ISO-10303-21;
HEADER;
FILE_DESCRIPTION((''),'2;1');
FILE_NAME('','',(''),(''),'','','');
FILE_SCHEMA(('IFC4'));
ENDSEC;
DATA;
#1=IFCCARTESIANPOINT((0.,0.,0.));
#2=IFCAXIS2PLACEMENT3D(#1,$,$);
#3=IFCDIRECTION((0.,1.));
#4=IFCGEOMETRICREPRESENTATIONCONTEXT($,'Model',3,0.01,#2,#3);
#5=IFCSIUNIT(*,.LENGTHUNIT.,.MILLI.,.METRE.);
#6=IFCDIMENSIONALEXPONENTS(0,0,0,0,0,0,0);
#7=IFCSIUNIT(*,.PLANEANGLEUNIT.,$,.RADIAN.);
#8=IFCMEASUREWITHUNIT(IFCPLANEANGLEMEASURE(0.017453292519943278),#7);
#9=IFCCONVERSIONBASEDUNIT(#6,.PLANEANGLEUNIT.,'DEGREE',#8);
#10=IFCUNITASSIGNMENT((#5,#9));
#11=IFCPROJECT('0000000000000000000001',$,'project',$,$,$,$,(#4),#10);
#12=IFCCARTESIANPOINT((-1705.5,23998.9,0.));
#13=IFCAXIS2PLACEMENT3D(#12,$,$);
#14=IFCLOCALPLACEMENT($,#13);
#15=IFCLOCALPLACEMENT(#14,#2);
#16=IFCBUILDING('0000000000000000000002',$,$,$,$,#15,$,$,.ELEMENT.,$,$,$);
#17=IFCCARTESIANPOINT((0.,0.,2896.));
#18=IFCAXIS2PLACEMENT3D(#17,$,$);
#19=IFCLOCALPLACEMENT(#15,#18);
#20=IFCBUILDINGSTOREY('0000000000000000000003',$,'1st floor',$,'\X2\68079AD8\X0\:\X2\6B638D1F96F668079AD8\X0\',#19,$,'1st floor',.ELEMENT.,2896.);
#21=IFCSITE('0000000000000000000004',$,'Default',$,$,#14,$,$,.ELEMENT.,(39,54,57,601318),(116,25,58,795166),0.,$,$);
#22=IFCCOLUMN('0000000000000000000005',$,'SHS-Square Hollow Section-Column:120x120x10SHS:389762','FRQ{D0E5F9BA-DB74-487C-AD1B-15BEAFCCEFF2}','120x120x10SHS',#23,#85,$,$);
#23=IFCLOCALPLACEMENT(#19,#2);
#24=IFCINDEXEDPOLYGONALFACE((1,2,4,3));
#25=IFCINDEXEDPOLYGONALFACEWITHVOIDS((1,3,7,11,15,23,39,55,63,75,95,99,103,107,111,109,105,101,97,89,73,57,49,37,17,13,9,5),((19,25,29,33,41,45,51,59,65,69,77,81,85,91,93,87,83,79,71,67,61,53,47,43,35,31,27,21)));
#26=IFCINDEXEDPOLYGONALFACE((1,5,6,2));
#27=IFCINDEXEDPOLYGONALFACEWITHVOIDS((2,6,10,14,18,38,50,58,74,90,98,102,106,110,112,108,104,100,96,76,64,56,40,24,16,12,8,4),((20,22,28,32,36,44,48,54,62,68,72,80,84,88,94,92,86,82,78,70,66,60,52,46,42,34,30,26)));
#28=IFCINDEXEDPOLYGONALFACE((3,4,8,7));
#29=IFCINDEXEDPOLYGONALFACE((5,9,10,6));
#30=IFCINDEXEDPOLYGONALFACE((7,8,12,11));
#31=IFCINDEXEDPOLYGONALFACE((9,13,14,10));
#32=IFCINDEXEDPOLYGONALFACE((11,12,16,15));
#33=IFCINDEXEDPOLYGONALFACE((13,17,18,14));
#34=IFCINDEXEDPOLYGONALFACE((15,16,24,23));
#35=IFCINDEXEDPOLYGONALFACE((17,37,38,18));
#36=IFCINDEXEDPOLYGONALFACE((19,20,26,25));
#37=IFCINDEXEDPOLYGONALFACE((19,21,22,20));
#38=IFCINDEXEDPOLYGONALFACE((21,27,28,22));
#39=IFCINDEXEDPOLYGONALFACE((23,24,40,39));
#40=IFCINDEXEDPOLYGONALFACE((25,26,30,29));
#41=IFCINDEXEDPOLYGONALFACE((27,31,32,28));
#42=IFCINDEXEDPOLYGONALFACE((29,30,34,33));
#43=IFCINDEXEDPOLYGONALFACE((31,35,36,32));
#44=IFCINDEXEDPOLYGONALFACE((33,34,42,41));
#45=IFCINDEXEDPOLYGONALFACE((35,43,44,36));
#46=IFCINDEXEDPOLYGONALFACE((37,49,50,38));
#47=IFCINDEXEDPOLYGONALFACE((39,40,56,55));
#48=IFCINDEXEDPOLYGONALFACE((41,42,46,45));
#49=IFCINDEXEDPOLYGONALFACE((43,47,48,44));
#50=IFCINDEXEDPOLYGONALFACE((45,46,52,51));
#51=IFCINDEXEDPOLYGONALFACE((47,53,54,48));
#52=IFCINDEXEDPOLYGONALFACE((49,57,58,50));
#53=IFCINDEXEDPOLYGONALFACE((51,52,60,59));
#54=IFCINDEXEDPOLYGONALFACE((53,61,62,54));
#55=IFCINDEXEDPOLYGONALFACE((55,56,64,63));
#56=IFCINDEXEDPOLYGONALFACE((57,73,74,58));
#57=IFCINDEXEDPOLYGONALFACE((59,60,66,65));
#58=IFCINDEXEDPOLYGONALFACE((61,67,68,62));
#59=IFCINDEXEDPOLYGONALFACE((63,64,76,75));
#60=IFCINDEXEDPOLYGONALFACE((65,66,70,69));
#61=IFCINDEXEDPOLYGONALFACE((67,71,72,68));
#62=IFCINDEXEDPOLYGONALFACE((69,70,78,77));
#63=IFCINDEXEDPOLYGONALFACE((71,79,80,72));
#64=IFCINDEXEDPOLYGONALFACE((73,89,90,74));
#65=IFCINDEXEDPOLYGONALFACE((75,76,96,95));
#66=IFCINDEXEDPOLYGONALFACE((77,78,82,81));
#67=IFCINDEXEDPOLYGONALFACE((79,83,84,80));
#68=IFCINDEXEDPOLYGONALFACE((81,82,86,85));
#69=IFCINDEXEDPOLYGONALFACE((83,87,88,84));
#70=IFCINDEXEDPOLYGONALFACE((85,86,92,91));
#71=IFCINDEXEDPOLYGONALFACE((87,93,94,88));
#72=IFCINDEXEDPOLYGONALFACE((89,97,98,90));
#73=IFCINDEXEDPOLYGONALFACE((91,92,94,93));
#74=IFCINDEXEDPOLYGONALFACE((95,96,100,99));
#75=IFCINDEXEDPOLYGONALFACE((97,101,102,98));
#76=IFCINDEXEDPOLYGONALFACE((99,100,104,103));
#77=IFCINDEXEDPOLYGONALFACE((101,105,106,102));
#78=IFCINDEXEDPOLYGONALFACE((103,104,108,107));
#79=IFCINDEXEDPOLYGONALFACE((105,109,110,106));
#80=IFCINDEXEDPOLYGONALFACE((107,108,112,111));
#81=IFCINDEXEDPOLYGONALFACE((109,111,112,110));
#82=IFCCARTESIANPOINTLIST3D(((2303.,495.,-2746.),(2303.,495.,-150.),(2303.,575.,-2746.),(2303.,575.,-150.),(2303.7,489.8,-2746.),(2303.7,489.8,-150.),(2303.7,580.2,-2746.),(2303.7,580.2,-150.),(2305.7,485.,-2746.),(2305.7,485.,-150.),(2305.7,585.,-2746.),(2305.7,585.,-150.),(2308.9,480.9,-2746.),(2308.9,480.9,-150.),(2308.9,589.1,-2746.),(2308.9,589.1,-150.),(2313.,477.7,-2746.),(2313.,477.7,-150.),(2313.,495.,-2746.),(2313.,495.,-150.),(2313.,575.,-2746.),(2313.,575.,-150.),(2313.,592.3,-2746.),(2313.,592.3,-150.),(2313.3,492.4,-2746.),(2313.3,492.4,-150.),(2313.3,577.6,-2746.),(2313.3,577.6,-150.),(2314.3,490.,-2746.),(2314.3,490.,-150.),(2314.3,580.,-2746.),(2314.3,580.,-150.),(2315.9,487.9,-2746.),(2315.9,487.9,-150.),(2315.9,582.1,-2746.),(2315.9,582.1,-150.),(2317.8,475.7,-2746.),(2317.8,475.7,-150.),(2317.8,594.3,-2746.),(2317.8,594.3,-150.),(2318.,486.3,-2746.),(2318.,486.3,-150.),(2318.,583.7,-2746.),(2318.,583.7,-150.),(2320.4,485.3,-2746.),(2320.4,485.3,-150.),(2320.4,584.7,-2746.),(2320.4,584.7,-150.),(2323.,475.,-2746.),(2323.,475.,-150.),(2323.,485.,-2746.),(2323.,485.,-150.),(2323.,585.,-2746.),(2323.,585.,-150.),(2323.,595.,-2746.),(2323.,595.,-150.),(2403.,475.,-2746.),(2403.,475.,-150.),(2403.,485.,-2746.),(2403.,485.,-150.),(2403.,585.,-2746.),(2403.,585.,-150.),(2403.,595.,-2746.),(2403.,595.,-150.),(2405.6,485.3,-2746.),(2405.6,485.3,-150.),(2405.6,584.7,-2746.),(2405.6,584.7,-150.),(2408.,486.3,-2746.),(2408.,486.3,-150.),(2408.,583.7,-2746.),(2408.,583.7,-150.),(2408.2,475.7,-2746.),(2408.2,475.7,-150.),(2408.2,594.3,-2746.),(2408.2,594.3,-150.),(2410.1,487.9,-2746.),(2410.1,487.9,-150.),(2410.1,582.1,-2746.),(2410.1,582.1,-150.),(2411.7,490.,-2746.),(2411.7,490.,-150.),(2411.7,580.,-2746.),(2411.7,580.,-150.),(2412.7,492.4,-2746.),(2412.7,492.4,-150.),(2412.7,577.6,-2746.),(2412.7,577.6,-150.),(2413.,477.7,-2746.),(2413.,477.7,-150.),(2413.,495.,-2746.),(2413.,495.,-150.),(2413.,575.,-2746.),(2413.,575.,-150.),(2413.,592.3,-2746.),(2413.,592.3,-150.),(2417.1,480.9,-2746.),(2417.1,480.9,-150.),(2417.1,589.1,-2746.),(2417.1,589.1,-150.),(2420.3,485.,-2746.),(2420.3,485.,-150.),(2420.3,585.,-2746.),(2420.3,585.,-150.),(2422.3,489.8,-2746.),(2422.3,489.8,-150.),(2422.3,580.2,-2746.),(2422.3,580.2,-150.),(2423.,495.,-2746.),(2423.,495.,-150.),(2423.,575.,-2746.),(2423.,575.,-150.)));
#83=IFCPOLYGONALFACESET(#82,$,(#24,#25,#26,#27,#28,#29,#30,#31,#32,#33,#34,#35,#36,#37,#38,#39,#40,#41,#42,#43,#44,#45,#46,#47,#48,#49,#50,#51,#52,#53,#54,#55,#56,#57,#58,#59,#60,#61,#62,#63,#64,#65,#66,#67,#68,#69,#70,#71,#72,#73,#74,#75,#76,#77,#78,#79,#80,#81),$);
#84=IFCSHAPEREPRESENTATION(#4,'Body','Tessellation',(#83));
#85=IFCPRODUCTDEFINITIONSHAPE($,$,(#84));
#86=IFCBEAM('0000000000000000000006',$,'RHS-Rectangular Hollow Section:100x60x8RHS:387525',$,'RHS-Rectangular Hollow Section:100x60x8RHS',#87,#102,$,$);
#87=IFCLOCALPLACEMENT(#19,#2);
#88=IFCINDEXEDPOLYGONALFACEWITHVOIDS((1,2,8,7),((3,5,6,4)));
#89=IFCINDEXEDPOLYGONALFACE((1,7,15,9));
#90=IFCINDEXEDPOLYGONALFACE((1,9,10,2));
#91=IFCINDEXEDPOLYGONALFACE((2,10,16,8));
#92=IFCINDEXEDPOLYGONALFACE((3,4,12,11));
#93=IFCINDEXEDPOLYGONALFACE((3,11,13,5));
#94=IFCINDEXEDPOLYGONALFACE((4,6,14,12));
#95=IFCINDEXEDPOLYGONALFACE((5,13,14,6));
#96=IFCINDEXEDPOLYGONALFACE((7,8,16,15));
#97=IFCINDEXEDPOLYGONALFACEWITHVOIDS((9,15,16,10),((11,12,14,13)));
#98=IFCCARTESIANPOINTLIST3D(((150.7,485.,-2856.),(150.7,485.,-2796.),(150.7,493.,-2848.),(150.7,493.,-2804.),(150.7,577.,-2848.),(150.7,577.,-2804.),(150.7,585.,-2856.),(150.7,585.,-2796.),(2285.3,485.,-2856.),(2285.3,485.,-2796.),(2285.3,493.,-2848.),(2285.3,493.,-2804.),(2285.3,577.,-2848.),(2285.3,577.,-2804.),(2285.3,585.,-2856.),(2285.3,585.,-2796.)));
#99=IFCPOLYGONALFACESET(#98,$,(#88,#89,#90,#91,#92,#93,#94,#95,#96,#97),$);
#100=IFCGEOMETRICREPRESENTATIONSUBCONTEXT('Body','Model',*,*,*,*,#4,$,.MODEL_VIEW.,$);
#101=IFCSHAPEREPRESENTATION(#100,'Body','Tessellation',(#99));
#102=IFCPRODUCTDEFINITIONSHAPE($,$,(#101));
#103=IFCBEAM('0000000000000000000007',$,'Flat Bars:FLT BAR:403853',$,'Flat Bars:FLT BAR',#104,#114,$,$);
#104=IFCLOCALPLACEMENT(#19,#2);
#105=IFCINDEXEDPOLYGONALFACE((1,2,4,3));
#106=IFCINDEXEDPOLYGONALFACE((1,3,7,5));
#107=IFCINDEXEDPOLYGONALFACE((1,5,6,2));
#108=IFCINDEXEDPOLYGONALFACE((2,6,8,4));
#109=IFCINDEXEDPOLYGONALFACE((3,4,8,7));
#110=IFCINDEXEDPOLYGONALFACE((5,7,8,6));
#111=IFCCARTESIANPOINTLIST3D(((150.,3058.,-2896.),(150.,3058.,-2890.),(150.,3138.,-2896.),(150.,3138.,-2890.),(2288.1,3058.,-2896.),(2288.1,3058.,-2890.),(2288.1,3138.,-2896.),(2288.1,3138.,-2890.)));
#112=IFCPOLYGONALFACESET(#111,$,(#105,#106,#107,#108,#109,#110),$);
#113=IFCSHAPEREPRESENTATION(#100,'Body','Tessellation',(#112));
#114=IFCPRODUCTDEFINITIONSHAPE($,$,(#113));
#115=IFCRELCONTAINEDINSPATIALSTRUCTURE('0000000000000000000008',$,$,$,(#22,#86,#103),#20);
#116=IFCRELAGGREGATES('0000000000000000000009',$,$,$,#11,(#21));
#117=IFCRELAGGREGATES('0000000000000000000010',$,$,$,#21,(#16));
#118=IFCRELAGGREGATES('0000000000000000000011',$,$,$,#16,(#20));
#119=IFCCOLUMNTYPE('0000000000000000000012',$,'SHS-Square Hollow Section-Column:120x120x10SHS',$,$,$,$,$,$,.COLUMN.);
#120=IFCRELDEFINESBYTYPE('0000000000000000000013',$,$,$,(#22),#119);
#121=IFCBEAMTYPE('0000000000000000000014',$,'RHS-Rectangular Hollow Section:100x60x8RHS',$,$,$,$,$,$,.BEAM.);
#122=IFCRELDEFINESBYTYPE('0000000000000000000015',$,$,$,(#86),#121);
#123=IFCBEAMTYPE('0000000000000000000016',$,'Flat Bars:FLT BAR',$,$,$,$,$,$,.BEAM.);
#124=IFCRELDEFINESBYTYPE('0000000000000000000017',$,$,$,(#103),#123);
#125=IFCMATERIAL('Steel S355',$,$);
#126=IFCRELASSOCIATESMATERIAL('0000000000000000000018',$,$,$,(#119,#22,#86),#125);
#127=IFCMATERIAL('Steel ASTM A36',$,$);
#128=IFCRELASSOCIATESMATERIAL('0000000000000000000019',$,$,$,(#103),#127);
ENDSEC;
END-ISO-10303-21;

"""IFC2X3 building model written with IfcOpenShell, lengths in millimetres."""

from ifc_helpers import new_model, entity, si_unit, converted_unit, direction, frame, frame_2d, origin, origin_2d, origin_2d_with_axis, place, context, subcontext, project, spatial, rectangle, hollow_rectangle, extrude, boolean, clip, halfspace, material, type_object, element, save


model = new_model("IFC2X3")

# Units and contexts
model_context = context("Model", 3, precision=0.01, world=origin(), true_north=direction((0.0, 1.0)))
body_context = subcontext(model_context, "Body", "Model", "MODEL_VIEW")
ifc_project = project(units=[si_unit("LENGTHUNIT", "METRE", prefix="MILLI"), converted_unit("PLANEANGLEUNIT", "DEGREE", entity("IfcPlaneAngleMeasure", 0.017453292519943278), si_unit("PLANEANGLEUNIT", "RADIAN"), dimensions=[0, 0, 0, 0, 0, 0, 0])], contexts=[model_context])

# Site, building, storey
site_placement = place(None, frame((-1705.5, 23998.9, 0.0)))
site = spatial("IfcSite", under=ifc_project, at=site_placement, Name="Default", CompositionType="ELEMENT", RefLatitude=(39, 54, 57, 601318), RefLongitude=(116, 25, 58, 795166), RefElevation=0.0)
building_placement = place(site_placement, origin())
building = spatial("IfcBuilding", under=site, at=building_placement, CompositionType="ELEMENT")
storey_placement = place(building_placement, frame((0.0, 0.0, 2896.0)))
storey = spatial("IfcBuildingStorey", under=building, at=storey_placement, Name="1st floor", ObjectType="标高:正负零标高", LongName="1st floor", CompositionType="ELEMENT", Elevation=2896.0)

# Column
ifc_material_1 = material(Name="Steel S355")
column_type_1 = type_object("IfcColumnType", Name="SHS-Square Hollow Section-Column:120x120x10SHS", PredefinedType="COLUMN", material=ifc_material_1)
column_1_placement = place(storey_placement, frame((2363.0, 535.0, -150.0), z_axis=(0.0, 0.0, 1.0), x_axis=(0.0, -1.0, 0.0)))
element("IfcColumn", 1, at=column_1_placement, inside=storey, type_object=column_type_1, material=ifc_material_1, Name="SHS-Square Hollow Section-Column:120x120x10SHS:389762", Description="FRQ{D0E5F9BA-DB74-487C-AD1B-15BEAFCCEFF2}", ObjectType="120x120x10SHS", context=model_context, shape_type="Clipping", body=[
    clip(extrude(hollow_rectangle(XDim=120.0, YDim=120.0, WallThickness=10.0, InnerFilletRadius=10.0, OuterFilletRadius=20.0, at=origin_2d()), origin(), (0.0, 0.0, -1.0), 2680.9), halfspace(frame((535.0, -2363.0, -2596.0), z_axis=(0.0, 0.0, 1.0), x_axis=(0.0, 1.0, 0.0)), True)),
])

# Beams
beam_type_1 = type_object("IfcBeamType", Name="RHS-Rectangular Hollow Section:100x60x8RHS", PredefinedType="BEAM")
beam_1_placement = place(storey_placement, frame((150.7, 585.0, -2826.0)))
element("IfcBeam", 2, at=beam_1_placement, inside=storey, type_object=beam_type_1, material=ifc_material_1, Name="RHS-Rectangular Hollow Section:100x60x8RHS:387525", ObjectType="RHS-Rectangular Hollow Section:100x60x8RHS", context=body_context, shape_type="SweptSolid", body=[
    boolean("DIFFERENCE", extrude(rectangle(XDim=60.0, YDim=100.0, at=frame_2d((0.0, 0.0), x_axis=(1.0, 0.0))), frame((0.0, -50.0, 0.0), z_axis=(1.0, 0.0, 0.0), x_axis=(0.0, 0.0, -1.0)), (0.0, 0.0, 1.0), 2134.6), extrude(rectangle(XDim=44.0, YDim=84.0, at=frame_2d((0.0, 0.0), x_axis=(0.0, 1.0))), frame((2134.6, -50.0, 0.0), z_axis=(-1.0, 0.0, 0.0), x_axis=(0.0, 1.0, 0.0)), (0.0, 0.0, 1.0), 2134.6)),
])
ifc_material_2 = material(Name="Steel ASTM A36")
beam_type_2 = type_object("IfcBeamType", Name="Flat Bars:FLT BAR", PredefinedType="BEAM")
beam_2_placement = place(storey_placement, frame((150.0, 3098.0, -2890.0)))
element("IfcBeam", 3, at=beam_2_placement, inside=storey, type_object=beam_type_2, material=ifc_material_2, Name="Flat Bars:FLT BAR:403853", ObjectType="Flat Bars:FLT BAR", context=body_context, shape_type="SweptSolid", body=[
    extrude(rectangle(XDim=6.0, YDim=80.0, at=origin_2d_with_axis()), frame((0.0, 0.0, -3.0), z_axis=(1.0, 0.0, 0.0), x_axis=(0.0, 0.0, -1.0)), (0.0, 0.0, 1.0), 2138.1),
])

save(model, "model.ifc")
